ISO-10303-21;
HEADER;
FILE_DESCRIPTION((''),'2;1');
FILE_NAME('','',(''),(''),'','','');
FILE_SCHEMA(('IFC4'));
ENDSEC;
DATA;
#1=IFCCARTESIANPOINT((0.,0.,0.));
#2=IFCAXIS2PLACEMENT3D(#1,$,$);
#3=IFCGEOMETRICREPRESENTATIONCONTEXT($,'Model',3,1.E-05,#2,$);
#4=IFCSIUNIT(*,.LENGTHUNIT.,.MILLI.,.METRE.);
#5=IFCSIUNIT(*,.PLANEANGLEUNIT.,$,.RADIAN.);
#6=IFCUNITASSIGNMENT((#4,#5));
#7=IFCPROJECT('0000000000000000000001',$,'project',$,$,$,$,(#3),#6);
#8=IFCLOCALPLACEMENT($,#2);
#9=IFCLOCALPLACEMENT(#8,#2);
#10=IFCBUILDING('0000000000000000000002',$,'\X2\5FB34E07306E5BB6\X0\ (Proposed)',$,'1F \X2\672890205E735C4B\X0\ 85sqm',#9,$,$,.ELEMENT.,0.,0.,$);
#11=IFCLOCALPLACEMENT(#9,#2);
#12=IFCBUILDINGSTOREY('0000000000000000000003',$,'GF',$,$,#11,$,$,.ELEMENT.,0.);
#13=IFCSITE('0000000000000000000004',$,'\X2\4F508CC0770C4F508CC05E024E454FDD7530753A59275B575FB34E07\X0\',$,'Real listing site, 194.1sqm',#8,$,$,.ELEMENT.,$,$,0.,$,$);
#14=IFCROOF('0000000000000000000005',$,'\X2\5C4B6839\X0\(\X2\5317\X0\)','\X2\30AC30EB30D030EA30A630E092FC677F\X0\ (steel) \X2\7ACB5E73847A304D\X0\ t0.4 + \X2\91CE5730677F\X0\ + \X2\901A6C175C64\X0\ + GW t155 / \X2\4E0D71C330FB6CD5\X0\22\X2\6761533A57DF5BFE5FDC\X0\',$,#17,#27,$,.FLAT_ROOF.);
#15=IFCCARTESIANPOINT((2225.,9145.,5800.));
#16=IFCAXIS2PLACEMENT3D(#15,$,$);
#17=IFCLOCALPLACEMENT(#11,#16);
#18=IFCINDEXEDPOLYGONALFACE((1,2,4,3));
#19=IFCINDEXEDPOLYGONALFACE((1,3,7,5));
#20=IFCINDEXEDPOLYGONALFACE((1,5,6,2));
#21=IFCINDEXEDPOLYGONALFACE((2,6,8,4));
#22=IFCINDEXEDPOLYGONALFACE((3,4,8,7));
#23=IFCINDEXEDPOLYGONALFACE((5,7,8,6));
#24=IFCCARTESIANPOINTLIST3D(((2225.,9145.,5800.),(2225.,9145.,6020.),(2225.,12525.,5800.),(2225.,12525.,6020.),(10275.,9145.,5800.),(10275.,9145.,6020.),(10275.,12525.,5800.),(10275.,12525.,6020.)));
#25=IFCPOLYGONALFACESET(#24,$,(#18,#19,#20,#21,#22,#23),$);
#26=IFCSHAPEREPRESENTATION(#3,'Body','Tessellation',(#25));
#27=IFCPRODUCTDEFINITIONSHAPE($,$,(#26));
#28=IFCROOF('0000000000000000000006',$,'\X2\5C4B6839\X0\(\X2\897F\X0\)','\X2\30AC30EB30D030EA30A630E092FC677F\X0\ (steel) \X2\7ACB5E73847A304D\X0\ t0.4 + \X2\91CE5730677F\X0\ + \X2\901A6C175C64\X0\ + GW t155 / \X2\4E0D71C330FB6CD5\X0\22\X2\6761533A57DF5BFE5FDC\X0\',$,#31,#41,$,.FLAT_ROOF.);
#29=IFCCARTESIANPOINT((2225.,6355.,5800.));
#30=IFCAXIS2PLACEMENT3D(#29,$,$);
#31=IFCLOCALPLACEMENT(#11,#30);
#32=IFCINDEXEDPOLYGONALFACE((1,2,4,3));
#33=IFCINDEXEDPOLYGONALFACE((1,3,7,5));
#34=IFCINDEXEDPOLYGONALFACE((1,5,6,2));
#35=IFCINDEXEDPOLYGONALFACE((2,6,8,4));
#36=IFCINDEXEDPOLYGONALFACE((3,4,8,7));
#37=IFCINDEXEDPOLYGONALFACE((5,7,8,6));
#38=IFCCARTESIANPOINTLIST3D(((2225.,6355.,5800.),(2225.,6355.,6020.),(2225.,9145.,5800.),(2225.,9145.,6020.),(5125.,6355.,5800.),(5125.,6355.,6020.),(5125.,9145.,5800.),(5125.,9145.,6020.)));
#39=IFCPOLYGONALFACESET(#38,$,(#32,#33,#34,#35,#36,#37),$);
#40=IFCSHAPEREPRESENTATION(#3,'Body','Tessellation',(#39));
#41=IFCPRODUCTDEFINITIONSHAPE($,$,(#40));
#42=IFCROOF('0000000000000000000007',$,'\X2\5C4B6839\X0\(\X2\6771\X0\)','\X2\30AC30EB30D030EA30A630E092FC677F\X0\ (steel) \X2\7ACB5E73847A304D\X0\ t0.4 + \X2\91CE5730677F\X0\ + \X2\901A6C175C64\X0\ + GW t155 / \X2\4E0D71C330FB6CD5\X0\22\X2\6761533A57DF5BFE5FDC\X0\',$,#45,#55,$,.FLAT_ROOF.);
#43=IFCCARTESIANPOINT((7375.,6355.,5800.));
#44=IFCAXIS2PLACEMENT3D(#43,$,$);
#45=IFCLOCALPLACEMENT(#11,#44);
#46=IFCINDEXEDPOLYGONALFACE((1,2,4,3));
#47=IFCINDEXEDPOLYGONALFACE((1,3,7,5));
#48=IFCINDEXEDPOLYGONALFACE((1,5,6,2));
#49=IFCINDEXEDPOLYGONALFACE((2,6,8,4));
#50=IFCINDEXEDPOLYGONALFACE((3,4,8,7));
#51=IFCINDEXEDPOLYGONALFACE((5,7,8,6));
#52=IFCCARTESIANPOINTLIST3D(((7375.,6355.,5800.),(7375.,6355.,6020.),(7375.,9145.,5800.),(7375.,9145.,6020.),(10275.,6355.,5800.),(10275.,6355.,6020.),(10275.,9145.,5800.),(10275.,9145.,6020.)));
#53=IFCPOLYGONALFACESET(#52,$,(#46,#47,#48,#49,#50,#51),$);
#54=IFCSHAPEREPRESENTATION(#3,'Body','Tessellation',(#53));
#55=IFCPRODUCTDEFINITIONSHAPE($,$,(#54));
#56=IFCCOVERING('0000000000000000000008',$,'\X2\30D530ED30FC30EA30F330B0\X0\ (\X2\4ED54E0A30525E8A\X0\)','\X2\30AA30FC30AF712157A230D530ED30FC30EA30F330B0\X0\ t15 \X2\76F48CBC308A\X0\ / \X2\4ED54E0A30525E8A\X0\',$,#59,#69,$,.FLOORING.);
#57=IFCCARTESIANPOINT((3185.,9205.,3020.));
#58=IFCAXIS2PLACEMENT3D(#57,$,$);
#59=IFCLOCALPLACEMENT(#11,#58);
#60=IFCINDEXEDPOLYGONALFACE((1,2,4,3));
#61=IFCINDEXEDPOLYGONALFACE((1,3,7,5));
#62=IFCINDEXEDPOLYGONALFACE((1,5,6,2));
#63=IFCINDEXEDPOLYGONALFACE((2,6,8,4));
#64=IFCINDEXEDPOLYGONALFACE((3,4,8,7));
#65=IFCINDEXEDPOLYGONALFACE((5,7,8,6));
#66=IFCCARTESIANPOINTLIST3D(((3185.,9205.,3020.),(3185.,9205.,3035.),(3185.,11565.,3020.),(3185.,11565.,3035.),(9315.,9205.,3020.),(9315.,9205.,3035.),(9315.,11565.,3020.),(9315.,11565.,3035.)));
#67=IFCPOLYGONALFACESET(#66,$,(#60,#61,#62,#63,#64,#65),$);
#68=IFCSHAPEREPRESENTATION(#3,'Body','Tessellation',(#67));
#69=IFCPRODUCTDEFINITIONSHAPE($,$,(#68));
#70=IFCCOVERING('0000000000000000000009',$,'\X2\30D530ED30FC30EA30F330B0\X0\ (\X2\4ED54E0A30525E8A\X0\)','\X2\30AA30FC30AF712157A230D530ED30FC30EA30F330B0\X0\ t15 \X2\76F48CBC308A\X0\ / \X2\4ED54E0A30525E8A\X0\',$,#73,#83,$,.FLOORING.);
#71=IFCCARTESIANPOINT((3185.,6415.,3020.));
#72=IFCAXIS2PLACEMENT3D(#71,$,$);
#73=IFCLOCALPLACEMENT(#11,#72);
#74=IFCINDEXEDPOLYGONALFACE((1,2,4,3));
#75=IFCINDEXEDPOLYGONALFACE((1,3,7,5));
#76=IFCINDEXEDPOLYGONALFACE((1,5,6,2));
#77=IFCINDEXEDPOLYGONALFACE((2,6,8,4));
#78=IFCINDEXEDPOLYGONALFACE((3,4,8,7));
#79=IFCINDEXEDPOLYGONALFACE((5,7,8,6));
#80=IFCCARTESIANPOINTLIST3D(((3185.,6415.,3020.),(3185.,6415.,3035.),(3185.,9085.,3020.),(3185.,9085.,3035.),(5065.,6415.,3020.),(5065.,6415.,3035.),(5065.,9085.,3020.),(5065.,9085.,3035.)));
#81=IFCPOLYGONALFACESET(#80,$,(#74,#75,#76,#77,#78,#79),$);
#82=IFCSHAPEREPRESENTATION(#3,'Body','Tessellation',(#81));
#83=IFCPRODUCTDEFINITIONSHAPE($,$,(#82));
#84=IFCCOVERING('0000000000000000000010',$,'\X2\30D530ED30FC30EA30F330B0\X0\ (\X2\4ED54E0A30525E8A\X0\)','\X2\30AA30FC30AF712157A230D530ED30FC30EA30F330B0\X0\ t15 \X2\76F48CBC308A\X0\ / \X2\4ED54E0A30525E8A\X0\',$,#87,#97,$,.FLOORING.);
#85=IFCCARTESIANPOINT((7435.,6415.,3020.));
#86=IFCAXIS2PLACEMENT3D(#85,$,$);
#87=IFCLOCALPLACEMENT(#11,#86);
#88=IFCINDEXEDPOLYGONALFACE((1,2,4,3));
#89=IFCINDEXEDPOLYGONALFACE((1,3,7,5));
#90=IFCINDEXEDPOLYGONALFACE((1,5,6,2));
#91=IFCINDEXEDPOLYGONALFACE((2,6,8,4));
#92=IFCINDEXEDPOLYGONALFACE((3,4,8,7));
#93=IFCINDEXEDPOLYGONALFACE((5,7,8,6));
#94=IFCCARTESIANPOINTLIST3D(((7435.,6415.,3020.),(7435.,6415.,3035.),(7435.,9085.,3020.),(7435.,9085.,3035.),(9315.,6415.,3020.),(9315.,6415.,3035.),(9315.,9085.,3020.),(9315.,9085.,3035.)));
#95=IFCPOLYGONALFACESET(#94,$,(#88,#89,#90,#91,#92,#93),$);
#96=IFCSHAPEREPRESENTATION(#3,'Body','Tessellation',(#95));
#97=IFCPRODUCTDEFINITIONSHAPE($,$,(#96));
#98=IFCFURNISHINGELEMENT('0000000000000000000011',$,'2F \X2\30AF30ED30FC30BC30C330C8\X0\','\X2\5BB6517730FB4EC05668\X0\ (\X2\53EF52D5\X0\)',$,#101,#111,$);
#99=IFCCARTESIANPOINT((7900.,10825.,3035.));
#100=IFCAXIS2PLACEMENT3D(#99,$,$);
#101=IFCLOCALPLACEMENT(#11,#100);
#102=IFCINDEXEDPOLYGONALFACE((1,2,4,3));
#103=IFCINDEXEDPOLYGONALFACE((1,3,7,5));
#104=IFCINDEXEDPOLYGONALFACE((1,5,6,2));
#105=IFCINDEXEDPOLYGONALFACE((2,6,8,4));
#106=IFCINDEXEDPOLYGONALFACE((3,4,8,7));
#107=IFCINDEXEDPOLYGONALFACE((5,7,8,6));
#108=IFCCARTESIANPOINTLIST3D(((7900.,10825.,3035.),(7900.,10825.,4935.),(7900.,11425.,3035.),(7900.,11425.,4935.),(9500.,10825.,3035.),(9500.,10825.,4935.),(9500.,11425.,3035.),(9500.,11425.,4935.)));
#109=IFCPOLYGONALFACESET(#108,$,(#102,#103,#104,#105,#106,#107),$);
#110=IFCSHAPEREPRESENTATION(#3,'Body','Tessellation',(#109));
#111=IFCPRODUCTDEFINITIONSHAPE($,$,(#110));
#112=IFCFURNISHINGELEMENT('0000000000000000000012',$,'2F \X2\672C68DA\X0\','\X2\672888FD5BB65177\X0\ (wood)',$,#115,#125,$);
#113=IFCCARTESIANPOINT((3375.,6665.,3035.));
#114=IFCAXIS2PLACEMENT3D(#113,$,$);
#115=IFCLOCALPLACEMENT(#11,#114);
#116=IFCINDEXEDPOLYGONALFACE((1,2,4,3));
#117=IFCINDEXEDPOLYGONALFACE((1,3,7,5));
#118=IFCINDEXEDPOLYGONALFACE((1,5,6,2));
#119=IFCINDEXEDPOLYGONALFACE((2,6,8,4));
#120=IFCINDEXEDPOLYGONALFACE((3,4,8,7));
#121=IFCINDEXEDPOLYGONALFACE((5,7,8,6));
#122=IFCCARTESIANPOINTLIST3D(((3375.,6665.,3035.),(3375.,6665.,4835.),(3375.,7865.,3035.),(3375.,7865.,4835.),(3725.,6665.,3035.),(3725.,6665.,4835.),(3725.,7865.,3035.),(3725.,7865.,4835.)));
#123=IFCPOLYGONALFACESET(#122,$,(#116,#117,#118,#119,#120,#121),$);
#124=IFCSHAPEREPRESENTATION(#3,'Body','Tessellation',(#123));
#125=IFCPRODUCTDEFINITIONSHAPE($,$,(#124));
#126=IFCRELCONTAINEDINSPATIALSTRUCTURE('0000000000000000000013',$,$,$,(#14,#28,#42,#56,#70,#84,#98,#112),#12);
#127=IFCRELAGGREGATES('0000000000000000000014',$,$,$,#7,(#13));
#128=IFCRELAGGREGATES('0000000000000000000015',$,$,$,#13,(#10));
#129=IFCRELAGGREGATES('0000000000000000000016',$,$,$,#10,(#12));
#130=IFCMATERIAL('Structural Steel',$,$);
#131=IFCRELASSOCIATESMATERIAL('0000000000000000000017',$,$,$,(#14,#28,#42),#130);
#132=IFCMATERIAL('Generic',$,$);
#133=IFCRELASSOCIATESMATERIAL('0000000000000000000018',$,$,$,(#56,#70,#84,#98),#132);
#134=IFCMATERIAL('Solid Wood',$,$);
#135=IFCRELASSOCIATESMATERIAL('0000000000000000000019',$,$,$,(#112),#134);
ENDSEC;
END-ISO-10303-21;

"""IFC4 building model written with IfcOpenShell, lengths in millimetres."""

from ifc_helpers import new_model, si_unit, frame, frame_2d, origin, place, context, project, spatial, rectangle, extrude, material, element, save


model = new_model("IFC4")

# Units and contexts
model_context = context("Model", 3, precision=1e-05, world=origin())
ifc_project = project(units=[si_unit("LENGTHUNIT", "METRE", prefix="MILLI"), si_unit("PLANEANGLEUNIT", "RADIAN")], contexts=[model_context])

# Site, building, storey
site_placement = place(None, origin())
site = spatial("IfcSite", under=ifc_project, at=site_placement, Name="佐賀県佐賀市久保田町大字徳万", ObjectType="Real listing site, 194.1sqm", CompositionType="ELEMENT", RefElevation=0.0)
building_placement = place(site_placement, origin())
building = spatial("IfcBuilding", under=site, at=building_placement, Name="徳万の家 (Proposed)", ObjectType="1F 木造平屋 85sqm", CompositionType="ELEMENT", ElevationOfRefHeight=0.0, ElevationOfTerrain=0.0)
storey_placement = place(building_placement, origin())
storey = spatial("IfcBuildingStorey", under=building, at=storey_placement, Name="GF", CompositionType="ELEMENT", Elevation=0.0)

# Shared definitions
ifc_material_1 = material(Name="Solid Wood")

# Shared definitions
ifc_material_2 = material(Name="Generic")

# Roofs
ifc_material_3 = material(Name="Structural Steel")
for number, where, name in (
    (1, (2225.0, 9145.0, 5800.0), "屋根(北)"),
):
    element("IfcRoof", number, at=place(storey_placement, frame(where)), inside=storey, material=ifc_material_3, Name=name, Description="ガルバリウム鋼板 (steel) 立平葺き t0.4 + 野地板 + 通気層 + GW t155 / 不燃・法22条区域対応", PredefinedType="FLAT_ROOF", context=model_context, shape_type="SweptSolid", body=[
        extrude(rectangle(XDim=8050.0, YDim=3380.0, at=frame_2d((4025.0, 1690.0))), frame((2225.0, 9145.0, 5800.0)), (0.0, 0.0, 1.0), 220.0),
    ])
roof_1_placement = place(storey_placement, frame((2225.0, 6355.0, 5800.0)))
element("IfcRoof", 2, at=roof_1_placement, inside=storey, material=ifc_material_3, Name="屋根(西)", Description="ガルバリウム鋼板 (steel) 立平葺き t0.4 + 野地板 + 通気層 + GW t155 / 不燃・法22条区域対応", PredefinedType="FLAT_ROOF", context=model_context, shape_type="SweptSolid", body=[
    extrude(rectangle(XDim=2900.0, YDim=2790.0, at=frame_2d((1450.0, 1395.0))), frame((2225.0, 6355.0, 5800.0)), (0.0, 0.0, 1.0), 220.0),
])
roof_2_placement = place(storey_placement, frame((7375.0, 6355.0, 5800.0)))
element("IfcRoof", 3, at=roof_2_placement, inside=storey, material=ifc_material_3, Name="屋根(東)", Description="ガルバリウム鋼板 (steel) 立平葺き t0.4 + 野地板 + 通気層 + GW t155 / 不燃・法22条区域対応", PredefinedType="FLAT_ROOF", context=model_context, shape_type="SweptSolid", body=[
    extrude(rectangle(XDim=2900.0, YDim=2790.0, at=frame_2d((1450.0, 1395.0))), frame((7375.0, 6355.0, 5800.0)), (0.0, 0.0, 1.0), 220.0),
])

# Coverings
covering_1_placement = place(storey_placement, frame((3185.0, 9205.0, 3020.0)))
element("IfcCovering", 4, at=covering_1_placement, inside=storey, material=ifc_material_2, Name="フローリング (仕上げ床)", Description="オーク無垢フローリング t15 直貼り / 仕上げ床", PredefinedType="FLOORING", context=model_context, shape_type="SweptSolid", body=[
    extrude(rectangle(XDim=6130.0, YDim=2360.0, at=frame_2d((3065.0, 1180.0))), frame((3185.0, 9205.0, 3020.0)), (0.0, 0.0, 1.0), 15.0),
])
covering_2_placement = place(storey_placement, frame((3185.0, 6415.0, 3020.0)))
element("IfcCovering", 5, at=covering_2_placement, inside=storey, material=ifc_material_2, Name="フローリング (仕上げ床)", Description="オーク無垢フローリング t15 直貼り / 仕上げ床", PredefinedType="FLOORING", context=model_context, shape_type="SweptSolid", body=[
    extrude(rectangle(XDim=1880.0, YDim=2670.0, at=frame_2d((940.0, 1335.0))), frame((3185.0, 6415.0, 3020.0)), (0.0, 0.0, 1.0), 15.0),
])
covering_3_placement = place(storey_placement, frame((7435.0, 6415.0, 3020.0)))
element("IfcCovering", 6, at=covering_3_placement, inside=storey, material=ifc_material_2, Name="フローリング (仕上げ床)", Description="オーク無垢フローリング t15 直貼り / 仕上げ床", PredefinedType="FLOORING", context=model_context, shape_type="SweptSolid", body=[
    extrude(rectangle(XDim=1880.0, YDim=2670.0, at=frame_2d((940.0, 1335.0))), frame((7435.0, 6415.0, 3020.0)), (0.0, 0.0, 1.0), 15.0),
])

# Furnishing elements
furnishing_1_placement = place(storey_placement, frame((7900.0, 10825.0, 3035.0)))
element("IfcFurnishingElement", 7, at=furnishing_1_placement, inside=storey, material=ifc_material_2, Name="2F クローゼット", Description="家具・什器 (可動)", context=model_context, shape_type="SweptSolid", body=[
    extrude(rectangle(XDim=1600.0, YDim=600.0, at=frame_2d((800.0, 300.0))), frame((7900.0, 10825.0, 3035.0)), (0.0, 0.0, 1.0), 1900.0),
])
furnishing_2_placement = place(storey_placement, frame((3375.0, 6665.0, 3035.0)))
element("IfcFurnishingElement", 8, at=furnishing_2_placement, inside=storey, material=ifc_material_1, Name="2F 本棚", Description="木製家具 (wood)", context=model_context, shape_type="SweptSolid", body=[
    extrude(rectangle(XDim=350.0, YDim=1200.0, at=frame_2d((175.0, 600.0))), frame((3375.0, 6665.0, 3035.0)), (0.0, 0.0, 1.0), 1800.0),
])

save(model, "model.ifc")
